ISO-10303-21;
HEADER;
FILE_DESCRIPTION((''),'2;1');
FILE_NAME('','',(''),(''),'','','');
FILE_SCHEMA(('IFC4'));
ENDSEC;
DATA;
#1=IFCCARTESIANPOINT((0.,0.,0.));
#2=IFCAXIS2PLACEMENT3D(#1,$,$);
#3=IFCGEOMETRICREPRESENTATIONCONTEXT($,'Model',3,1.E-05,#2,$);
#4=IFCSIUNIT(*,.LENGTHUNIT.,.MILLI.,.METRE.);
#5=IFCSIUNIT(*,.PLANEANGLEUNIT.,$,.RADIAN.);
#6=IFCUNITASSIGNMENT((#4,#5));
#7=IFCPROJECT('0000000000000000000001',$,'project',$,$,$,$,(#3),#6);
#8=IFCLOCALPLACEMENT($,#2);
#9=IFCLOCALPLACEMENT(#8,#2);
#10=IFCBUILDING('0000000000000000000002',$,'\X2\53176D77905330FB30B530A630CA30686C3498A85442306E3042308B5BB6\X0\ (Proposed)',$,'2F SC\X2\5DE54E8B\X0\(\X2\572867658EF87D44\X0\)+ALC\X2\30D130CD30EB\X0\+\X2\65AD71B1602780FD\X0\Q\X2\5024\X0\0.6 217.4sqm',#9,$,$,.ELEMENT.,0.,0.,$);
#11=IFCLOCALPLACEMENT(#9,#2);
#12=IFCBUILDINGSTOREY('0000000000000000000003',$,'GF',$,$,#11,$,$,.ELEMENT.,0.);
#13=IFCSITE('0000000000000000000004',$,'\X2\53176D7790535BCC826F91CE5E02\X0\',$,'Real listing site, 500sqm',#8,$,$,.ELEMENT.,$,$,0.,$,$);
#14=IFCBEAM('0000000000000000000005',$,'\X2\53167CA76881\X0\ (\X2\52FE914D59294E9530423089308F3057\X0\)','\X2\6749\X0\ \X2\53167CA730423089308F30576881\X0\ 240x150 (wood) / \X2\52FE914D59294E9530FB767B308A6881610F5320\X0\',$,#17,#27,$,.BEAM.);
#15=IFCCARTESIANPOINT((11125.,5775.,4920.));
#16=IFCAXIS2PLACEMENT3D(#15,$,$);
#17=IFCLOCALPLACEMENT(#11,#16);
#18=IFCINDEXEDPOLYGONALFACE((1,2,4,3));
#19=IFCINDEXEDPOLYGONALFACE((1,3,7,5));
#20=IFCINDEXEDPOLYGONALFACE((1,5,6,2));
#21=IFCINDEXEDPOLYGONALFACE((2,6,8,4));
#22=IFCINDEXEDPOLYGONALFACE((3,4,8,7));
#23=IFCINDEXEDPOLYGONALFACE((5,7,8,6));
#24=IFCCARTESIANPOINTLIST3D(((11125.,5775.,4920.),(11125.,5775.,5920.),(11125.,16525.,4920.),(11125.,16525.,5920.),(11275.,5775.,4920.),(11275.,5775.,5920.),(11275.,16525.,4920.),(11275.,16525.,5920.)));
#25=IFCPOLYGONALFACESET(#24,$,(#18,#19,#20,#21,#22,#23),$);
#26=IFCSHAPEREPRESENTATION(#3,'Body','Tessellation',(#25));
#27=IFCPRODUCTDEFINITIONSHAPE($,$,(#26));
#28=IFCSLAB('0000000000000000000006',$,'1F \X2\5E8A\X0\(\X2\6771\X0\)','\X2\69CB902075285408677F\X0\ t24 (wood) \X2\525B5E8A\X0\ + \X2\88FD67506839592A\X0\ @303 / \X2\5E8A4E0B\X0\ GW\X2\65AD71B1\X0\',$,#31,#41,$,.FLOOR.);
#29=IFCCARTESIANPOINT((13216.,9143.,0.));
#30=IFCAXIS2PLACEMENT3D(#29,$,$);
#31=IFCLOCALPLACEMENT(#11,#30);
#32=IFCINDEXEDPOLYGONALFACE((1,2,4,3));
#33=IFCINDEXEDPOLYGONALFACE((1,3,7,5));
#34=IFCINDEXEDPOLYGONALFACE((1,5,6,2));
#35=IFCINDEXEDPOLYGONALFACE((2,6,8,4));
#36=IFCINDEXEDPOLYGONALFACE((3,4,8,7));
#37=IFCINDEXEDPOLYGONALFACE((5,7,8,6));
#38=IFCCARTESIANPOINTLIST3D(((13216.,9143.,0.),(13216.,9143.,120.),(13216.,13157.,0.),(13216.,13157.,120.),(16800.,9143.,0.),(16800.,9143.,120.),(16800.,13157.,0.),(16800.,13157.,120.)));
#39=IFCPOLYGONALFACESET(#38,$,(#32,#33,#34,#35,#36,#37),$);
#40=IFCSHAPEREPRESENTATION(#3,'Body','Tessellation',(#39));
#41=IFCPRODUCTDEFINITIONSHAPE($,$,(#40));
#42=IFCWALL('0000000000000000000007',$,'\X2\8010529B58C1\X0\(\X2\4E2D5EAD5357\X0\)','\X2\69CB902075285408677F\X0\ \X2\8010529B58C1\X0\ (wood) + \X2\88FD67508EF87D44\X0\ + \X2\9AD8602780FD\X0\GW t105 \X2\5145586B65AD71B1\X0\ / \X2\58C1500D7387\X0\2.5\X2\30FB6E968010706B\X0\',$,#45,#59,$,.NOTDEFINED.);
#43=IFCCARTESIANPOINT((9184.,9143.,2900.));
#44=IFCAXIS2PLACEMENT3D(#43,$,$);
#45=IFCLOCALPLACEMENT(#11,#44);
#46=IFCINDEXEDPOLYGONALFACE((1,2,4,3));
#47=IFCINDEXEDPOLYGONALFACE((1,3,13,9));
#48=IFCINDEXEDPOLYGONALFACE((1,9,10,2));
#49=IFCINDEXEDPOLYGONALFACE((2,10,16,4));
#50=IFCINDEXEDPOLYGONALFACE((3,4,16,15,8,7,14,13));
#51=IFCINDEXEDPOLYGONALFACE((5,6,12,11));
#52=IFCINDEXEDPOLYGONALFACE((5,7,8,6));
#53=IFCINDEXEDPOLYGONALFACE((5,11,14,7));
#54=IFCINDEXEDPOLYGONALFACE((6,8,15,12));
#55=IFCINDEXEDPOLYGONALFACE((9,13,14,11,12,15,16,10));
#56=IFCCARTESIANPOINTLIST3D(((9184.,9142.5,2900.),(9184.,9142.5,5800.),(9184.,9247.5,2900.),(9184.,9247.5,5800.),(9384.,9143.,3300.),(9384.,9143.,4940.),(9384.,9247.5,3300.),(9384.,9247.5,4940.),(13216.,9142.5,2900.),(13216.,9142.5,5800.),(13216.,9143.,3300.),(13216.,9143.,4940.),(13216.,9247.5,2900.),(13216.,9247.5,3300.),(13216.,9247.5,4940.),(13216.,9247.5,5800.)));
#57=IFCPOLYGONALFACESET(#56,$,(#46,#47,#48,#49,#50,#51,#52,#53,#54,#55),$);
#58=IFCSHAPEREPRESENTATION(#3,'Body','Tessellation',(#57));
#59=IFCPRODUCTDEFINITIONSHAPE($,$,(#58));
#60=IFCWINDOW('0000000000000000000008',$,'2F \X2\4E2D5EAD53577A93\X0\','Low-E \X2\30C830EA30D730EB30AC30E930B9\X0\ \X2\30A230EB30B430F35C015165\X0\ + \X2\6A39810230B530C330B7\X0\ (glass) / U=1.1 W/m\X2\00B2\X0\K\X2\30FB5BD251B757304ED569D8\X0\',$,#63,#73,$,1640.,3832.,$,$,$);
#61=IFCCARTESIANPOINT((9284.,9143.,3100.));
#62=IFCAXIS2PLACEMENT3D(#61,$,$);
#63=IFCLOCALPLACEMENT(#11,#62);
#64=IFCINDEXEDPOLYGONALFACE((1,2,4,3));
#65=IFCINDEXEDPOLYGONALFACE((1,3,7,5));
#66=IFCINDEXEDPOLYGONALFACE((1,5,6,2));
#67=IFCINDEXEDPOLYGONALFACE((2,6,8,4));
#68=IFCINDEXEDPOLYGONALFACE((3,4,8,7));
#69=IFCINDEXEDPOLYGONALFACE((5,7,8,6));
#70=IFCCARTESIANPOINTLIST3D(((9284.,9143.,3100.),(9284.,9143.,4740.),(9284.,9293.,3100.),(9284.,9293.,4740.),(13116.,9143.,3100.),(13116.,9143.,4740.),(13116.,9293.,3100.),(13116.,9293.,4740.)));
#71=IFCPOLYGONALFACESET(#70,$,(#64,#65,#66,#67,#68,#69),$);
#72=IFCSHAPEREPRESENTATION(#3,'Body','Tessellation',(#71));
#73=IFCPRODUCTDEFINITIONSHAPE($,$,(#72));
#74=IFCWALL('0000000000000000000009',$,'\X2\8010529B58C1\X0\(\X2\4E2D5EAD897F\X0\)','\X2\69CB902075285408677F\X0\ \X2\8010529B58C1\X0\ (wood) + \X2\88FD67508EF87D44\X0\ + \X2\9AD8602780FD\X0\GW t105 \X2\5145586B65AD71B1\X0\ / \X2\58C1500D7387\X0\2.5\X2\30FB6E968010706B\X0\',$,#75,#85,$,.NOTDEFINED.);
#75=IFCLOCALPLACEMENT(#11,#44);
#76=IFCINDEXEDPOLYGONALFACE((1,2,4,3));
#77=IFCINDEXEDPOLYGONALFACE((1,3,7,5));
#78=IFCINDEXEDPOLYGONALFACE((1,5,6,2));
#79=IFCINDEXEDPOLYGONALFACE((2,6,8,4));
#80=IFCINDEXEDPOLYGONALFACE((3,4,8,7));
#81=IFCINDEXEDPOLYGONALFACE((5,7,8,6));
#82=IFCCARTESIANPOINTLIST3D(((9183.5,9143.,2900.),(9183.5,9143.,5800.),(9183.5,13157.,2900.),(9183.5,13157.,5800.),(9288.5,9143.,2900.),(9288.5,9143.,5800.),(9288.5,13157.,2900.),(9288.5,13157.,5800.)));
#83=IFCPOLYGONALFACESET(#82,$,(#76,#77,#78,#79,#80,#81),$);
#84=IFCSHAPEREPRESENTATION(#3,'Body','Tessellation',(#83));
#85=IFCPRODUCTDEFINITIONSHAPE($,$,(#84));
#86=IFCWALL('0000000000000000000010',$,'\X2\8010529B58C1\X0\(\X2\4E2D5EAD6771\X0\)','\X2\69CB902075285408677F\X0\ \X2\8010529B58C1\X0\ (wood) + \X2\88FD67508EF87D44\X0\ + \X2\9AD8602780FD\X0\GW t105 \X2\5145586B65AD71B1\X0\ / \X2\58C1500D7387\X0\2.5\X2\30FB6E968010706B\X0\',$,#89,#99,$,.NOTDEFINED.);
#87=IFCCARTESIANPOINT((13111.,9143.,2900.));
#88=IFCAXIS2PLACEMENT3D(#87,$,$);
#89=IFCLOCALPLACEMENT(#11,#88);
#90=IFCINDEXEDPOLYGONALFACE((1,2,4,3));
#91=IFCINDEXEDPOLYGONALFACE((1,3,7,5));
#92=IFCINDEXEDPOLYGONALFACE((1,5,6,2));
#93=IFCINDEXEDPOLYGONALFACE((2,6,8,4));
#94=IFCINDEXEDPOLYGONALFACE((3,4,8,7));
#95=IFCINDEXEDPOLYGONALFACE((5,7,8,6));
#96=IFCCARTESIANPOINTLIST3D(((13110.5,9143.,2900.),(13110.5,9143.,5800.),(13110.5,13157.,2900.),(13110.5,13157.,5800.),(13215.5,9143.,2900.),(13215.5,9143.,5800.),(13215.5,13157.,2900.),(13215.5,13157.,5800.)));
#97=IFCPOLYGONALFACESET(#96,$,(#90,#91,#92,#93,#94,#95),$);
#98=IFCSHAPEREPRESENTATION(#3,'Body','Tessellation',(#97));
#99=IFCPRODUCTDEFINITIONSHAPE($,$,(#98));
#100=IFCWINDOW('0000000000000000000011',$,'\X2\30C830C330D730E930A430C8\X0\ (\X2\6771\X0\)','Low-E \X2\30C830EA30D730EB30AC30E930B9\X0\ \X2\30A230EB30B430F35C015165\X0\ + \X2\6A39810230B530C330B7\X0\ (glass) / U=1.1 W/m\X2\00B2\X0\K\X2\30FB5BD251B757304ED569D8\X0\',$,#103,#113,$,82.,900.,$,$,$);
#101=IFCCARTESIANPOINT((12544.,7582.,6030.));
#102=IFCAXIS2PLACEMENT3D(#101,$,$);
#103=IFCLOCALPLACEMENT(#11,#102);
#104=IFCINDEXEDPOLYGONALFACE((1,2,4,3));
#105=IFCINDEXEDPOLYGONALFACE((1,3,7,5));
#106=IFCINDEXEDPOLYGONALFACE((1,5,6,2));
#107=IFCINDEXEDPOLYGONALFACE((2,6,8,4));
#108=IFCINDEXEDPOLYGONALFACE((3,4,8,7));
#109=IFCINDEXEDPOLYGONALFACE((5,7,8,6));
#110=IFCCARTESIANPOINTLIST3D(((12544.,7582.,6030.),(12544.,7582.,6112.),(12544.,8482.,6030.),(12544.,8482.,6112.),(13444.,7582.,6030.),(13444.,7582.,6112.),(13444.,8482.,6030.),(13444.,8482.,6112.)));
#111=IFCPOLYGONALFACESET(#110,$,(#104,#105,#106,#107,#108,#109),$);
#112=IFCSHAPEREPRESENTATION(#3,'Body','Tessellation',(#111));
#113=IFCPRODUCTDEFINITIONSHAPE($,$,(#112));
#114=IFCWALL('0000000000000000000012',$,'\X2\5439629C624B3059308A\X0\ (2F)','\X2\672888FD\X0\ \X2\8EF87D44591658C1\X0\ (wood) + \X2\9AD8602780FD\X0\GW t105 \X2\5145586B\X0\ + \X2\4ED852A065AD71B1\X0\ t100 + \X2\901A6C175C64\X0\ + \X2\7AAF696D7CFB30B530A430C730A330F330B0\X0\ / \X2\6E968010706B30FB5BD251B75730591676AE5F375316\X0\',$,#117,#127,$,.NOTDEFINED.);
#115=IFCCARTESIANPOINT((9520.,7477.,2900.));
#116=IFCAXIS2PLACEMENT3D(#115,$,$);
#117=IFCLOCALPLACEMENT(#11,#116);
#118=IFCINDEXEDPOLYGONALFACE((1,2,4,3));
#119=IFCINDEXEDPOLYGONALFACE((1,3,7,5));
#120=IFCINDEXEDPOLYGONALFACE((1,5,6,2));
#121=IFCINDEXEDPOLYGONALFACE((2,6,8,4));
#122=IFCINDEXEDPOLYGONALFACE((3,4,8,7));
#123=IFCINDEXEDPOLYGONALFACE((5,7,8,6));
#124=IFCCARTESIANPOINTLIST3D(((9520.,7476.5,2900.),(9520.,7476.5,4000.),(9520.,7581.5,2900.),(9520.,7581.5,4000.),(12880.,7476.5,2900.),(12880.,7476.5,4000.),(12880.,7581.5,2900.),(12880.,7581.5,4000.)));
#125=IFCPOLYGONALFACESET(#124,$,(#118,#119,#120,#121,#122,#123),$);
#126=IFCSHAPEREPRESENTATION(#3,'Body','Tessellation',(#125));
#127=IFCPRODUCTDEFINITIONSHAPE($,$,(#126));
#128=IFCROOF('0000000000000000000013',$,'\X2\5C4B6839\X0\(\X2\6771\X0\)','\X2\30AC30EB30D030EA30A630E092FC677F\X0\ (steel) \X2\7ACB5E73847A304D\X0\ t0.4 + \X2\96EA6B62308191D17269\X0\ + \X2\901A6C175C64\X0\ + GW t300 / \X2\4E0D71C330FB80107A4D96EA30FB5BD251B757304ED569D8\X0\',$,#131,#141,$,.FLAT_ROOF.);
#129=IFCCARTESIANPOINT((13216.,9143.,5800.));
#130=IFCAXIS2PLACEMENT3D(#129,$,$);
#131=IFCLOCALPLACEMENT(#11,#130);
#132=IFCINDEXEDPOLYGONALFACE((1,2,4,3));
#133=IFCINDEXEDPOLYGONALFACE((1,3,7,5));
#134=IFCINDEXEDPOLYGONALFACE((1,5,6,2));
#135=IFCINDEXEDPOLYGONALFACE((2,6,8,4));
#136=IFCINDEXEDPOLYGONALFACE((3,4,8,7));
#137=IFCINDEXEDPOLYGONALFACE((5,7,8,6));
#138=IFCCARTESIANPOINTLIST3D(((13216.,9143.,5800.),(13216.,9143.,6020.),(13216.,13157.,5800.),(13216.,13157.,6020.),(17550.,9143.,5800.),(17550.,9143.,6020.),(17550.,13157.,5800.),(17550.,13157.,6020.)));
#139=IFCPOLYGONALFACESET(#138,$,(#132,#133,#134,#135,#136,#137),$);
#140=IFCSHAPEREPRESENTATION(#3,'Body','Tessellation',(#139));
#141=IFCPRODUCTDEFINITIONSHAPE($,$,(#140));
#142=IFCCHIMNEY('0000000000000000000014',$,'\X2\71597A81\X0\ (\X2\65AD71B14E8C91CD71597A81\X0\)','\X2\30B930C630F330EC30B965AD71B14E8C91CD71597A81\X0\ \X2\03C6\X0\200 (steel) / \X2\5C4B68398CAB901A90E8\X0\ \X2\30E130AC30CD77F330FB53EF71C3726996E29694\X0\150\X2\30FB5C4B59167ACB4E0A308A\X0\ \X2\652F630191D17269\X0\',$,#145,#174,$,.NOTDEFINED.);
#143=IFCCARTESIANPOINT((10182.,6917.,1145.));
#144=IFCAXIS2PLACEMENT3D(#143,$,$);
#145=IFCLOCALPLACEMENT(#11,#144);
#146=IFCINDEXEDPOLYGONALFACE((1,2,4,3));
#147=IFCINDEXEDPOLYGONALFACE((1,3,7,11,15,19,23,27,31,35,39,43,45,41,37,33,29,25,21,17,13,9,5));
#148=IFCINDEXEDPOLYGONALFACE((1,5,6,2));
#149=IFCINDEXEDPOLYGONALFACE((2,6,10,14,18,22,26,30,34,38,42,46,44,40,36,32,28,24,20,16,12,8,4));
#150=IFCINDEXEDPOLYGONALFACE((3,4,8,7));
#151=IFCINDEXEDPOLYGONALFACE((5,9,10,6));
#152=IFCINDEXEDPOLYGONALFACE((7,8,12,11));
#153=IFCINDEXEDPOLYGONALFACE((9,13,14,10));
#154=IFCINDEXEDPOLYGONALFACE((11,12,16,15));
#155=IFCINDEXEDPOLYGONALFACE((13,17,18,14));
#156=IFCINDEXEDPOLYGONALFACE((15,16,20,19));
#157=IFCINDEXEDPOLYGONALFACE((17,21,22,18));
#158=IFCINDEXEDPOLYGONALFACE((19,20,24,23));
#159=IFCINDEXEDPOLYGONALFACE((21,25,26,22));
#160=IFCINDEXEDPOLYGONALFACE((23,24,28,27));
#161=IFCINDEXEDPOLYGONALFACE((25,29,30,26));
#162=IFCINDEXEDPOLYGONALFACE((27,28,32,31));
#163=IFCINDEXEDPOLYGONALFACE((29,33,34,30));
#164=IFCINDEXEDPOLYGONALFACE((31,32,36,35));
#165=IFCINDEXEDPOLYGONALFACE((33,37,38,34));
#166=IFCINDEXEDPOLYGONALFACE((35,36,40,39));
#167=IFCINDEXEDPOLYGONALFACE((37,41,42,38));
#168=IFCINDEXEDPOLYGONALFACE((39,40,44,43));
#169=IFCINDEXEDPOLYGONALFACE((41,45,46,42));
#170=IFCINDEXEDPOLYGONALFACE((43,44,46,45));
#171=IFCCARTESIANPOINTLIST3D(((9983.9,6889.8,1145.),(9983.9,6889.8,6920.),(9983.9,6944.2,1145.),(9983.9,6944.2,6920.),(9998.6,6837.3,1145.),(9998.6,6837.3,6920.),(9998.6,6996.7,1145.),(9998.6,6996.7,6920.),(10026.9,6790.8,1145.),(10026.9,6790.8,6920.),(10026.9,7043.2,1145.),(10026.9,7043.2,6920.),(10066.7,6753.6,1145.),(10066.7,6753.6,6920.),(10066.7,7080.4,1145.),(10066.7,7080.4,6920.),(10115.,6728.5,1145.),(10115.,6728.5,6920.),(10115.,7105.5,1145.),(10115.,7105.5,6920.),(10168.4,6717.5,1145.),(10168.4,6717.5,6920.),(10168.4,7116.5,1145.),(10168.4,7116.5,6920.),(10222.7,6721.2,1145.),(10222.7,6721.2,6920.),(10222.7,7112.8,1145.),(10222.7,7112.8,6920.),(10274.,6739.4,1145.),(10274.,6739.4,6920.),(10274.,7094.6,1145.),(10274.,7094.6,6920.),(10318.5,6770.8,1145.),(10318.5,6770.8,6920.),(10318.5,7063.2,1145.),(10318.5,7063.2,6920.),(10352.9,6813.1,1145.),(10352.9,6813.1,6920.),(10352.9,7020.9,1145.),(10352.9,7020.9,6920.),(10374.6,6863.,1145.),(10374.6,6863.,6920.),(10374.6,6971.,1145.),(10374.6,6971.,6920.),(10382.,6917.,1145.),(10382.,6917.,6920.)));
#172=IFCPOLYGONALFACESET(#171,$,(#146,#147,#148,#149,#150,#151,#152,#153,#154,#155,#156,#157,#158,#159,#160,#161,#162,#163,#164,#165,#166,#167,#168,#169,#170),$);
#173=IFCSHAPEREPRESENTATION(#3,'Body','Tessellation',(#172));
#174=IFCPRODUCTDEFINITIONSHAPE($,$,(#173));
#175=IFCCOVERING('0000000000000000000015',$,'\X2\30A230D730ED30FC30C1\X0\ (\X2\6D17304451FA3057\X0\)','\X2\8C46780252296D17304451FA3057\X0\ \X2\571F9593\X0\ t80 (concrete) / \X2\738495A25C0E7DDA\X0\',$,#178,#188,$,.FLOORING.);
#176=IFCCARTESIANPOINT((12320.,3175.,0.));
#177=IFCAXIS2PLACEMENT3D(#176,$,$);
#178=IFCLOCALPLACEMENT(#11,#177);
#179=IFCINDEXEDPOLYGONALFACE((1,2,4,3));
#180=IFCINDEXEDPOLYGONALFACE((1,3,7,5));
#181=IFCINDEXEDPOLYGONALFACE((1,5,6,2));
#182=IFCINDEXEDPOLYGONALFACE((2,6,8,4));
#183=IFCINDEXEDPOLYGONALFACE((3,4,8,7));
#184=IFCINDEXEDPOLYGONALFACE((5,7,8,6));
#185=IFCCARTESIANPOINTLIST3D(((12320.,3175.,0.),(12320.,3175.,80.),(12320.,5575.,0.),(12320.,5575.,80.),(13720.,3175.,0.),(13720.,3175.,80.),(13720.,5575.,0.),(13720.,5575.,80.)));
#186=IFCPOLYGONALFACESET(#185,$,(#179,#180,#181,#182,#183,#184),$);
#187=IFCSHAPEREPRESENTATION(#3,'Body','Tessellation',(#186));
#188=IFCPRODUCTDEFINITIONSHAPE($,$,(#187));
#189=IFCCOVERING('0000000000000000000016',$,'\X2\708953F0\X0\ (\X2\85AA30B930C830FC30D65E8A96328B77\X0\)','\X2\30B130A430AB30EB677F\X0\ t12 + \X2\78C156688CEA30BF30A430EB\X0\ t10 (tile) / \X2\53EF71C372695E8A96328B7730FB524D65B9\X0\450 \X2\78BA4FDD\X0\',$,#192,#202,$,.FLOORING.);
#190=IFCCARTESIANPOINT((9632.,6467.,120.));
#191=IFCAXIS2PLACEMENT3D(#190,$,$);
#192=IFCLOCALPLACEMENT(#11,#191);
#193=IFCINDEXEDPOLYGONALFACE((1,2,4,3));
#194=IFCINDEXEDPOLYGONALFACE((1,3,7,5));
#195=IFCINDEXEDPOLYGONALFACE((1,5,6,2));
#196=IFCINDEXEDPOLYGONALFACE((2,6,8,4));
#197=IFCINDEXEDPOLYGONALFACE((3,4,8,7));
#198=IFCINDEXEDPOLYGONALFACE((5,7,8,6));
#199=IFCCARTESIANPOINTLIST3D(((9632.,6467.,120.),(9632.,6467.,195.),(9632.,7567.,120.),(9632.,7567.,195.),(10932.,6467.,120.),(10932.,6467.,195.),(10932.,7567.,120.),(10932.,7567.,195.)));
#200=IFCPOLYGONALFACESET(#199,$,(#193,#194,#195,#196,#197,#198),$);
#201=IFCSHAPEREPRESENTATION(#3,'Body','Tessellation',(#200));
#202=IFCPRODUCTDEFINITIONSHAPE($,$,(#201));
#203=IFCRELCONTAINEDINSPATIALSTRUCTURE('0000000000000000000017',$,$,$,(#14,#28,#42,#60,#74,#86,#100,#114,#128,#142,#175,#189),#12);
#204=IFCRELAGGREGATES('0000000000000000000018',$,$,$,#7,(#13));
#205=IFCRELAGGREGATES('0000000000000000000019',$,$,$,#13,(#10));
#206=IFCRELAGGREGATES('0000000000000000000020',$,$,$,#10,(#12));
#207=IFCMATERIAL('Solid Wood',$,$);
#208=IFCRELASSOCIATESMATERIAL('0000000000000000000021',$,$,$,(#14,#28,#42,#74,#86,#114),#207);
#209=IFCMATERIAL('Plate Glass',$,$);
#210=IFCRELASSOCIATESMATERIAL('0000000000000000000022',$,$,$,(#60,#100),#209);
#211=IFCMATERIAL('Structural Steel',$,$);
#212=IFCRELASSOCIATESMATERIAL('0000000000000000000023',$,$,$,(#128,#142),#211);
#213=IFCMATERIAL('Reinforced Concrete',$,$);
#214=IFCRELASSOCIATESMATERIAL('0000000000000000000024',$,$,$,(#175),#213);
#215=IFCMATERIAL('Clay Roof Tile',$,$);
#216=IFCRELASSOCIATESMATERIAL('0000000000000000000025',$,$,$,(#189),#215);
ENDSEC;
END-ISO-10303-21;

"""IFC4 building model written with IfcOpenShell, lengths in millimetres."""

from ifc_helpers import new_model, si_unit, frame, frame_2d, origin, origin_2d, place, context, project, spatial, rectangle, circle, extrude, material, element, fill, save


model = new_model("IFC4")

# Units and contexts
model_context = context("Model", 3, precision=1e-05, world=origin())
ifc_project = project(units=[si_unit("LENGTHUNIT", "METRE", prefix="MILLI"), si_unit("PLANEANGLEUNIT", "RADIAN")], contexts=[model_context])

# Site, building, storey
site_placement = place(None, origin())
site = spatial("IfcSite", under=ifc_project, at=site_placement, Name="北海道富良野市", ObjectType="Real listing site, 500sqm", CompositionType="ELEMENT", RefElevation=0.0)
building_placement = place(site_placement, origin())
building = spatial("IfcBuilding", under=site, at=building_placement, Name="北海道・サウナと水風呂のある家 (Proposed)", ObjectType="2F SC工事(在来軸組)+ALCパネル+断熱性能Q値0.6 217.4sqm", CompositionType="ELEMENT", ElevationOfRefHeight=0.0, ElevationOfTerrain=0.0)
storey_placement = place(building_placement, origin())
storey = spatial("IfcBuildingStorey", under=building, at=storey_placement, Name="GF", CompositionType="ELEMENT", Elevation=0.0)

# Shared definitions
ifc_material_1 = material(Name="Solid Wood")

# Beam
beam_placement = place(storey_placement, frame((11125.0, 5775.0, 4920.0)))
element("IfcBeam", 1, at=beam_placement, inside=storey, material=ifc_material_1, Name="化粧梁 (勾配天井あらわし)", Description="杉 化粧あらわし梁 240x150 (wood) / 勾配天井・登り梁意匠", PredefinedType="BEAM", context=model_context, shape_type="SweptSolid", body=[
    extrude(rectangle(XDim=150.0, YDim=10750.0, at=frame_2d((75.0, 5375.0))), frame((11125.0, 5775.0, 4920.0)), (0.0, 0.0, 1.0), 1000.0),
])

# Slab
slab_placement = place(storey_placement, frame((13216.0, 9143.0, 0.0)))
element("IfcSlab", 2, at=slab_placement, inside=storey, material=ifc_material_1, Name="1F 床(東)", Description="構造用合板 t24 (wood) 剛床 + 製材根太 @303 / 床下 GW断熱", PredefinedType="FLOOR", context=model_context, shape_type="SweptSolid", body=[
    extrude(rectangle(XDim=3584.0, YDim=4014.0, at=frame_2d((1792.0, 2007.0))), frame((13216.0, 9143.0, 0.0)), (0.0, 0.0, 1.0), 120.0),
])

# Wall, opening, window
wall_1_placement = place(storey_placement, frame((9184.0, 9143.0, 2900.0)))
wall_1 = element("IfcWall", 3, at=wall_1_placement, inside=storey, material=ifc_material_1, Name="耐力壁(中庭南)", Description="構造用合板 耐力壁 (wood) + 製材軸組 + 高性能GW t105 充填断熱 / 壁倍率2.5・準耐火", PredefinedType="NOTDEFINED", context=model_context, shape_type="SweptSolid", body=[
    extrude(rectangle(XDim=4032.0, YDim=105.0, at=frame_2d((2016.0, 52.0))), frame((9184.0, 9143.0, 2900.0)), (0.0, 0.0, 1.0), 2900.0),
])
opening_placement = place(storey_placement, frame((9284.0, 9143.0, 3100.0)))
opening = element("IfcOpeningElement", 4, at=opening_placement, cuts=wall_1, PredefinedType="NOTDEFINED", context=model_context, shape_type="SweptSolid", body=[
    extrude(rectangle(XDim=3832.0, YDim=150.0, at=frame_2d((1916.0, 75.0))), frame((9284.0, 9143.0, 3100.0)), (0.0, 0.0, 1.0), 1640.0),
])
ifc_material_2 = material(Name="Plate Glass")
window_1_placement = place(storey_placement, frame((9284.0, 9143.0, 3100.0)))
window_1 = element("IfcWindow", 5, at=window_1_placement, inside=storey, material=ifc_material_2, Name="2F 中庭南窓", Description="Low-E トリプルガラス アルゴン封入 + 樹脂サッシ (glass) / U=1.1 W/m²K・寒冷地仕様", OverallHeight=1640.0, OverallWidth=3832.0, context=model_context, shape_type="SweptSolid", body=[
    extrude(rectangle(XDim=3832.0, YDim=150.0, at=frame_2d((1916.0, 75.0))), frame((9284.0, 9143.0, 3100.0)), (0.0, 0.0, 1.0), 1640.0),
])
fill(opening, window_1)

# Walls
wall_2_placement = place(storey_placement, frame((9184.0, 9143.0, 2900.0)))
element("IfcWall", 6, at=wall_2_placement, inside=storey, material=ifc_material_1, Name="耐力壁(中庭西)", Description="構造用合板 耐力壁 (wood) + 製材軸組 + 高性能GW t105 充填断熱 / 壁倍率2.5・準耐火", PredefinedType="NOTDEFINED", context=model_context, shape_type="SweptSolid", body=[
    extrude(rectangle(XDim=105.0, YDim=4014.0, at=frame_2d((52.0, 2007.0))), frame((9184.0, 9143.0, 2900.0)), (0.0, 0.0, 1.0), 2900.0),
])
wall_3_placement = place(storey_placement, frame((13111.0, 9143.0, 2900.0)))
element("IfcWall", 7, at=wall_3_placement, inside=storey, material=ifc_material_1, Name="耐力壁(中庭東)", Description="構造用合板 耐力壁 (wood) + 製材軸組 + 高性能GW t105 充填断熱 / 壁倍率2.5・準耐火", PredefinedType="NOTDEFINED", context=model_context, shape_type="SweptSolid", body=[
    extrude(rectangle(XDim=105.0, YDim=4014.0, at=frame_2d((52.0, 2007.0))), frame((13111.0, 9143.0, 2900.0)), (0.0, 0.0, 1.0), 2900.0),
])

# Window
window_2_placement = place(storey_placement, frame((12544.0, 7582.0, 6030.0)))
element("IfcWindow", 8, at=window_2_placement, inside=storey, material=ifc_material_2, Name="トップライト (東)", Description="Low-E トリプルガラス アルゴン封入 + 樹脂サッシ (glass) / U=1.1 W/m²K・寒冷地仕様", OverallHeight=82.0, OverallWidth=900.0, context=model_context, shape_type="SweptSolid", body=[
    extrude(rectangle(XDim=900.0, YDim=900.0, at=frame_2d((450.0, 450.0))), frame((12544.0, 7582.0, 6030.0)), (0.0, 0.0, 1.0), 82.0),
])

# Wall
wall_4_placement = place(storey_placement, frame((9520.0, 7477.0, 2900.0)))
element("IfcWall", 9, at=wall_4_placement, inside=storey, material=ifc_material_1, Name="吹抜手すり (2F)", Description="木製 軸組外壁 (wood) + 高性能GW t105 充填 + 付加断熱 t100 + 通気層 + 窯業系サイディング / 準耐火・寒冷地外皮強化", PredefinedType="NOTDEFINED", context=model_context, shape_type="SweptSolid", body=[
    extrude(rectangle(XDim=3360.0, YDim=105.0, at=frame_2d((1680.0, 52.0))), frame((9520.0, 7477.0, 2900.0)), (0.0, 0.0, 1.0), 1100.0),
])

# Roof
ifc_material_3 = material(Name="Structural Steel")
roof_placement = place(storey_placement, frame((13216.0, 9143.0, 5800.0)))
element("IfcRoof", 10, at=roof_placement, inside=storey, material=ifc_material_3, Name="屋根(東)", Description="ガルバリウム鋼板 (steel) 立平葺き t0.4 + 雪止め金物 + 通気層 + GW t300 / 不燃・耐積雪・寒冷地仕様", PredefinedType="FLAT_ROOF", context=model_context, shape_type="SweptSolid", body=[
    extrude(rectangle(XDim=4334.0, YDim=4014.0, at=frame_2d((2167.0, 2007.0))), frame((13216.0, 9143.0, 5800.0)), (0.0, 0.0, 1.0), 220.0),
])

# Chimney
chimney_placement = place(storey_placement, frame((10182.0, 6917.0, 1145.0)))
element("IfcChimney", 11, at=chimney_placement, inside=storey, material=ifc_material_3, Name="煙突 (断熱二重煙突)", Description="ステンレス断熱二重煙突 φ200 (steel) / 屋根貫通部 メガネ石・可燃物離隔150・屋外立上り 支持金物", PredefinedType="NOTDEFINED", context=model_context, shape_type="SweptSolid", body=[
    extrude(circle(Radius=200.0, at=origin_2d()), frame((10182.0, 6917.0, 1145.0)), (0.0, 0.0, 1.0), 5775.0),
])

# Coverings
ifc_material_4 = material(Name="Reinforced Concrete")
covering_1_placement = place(storey_placement, frame((12320.0, 3175.0, 0.0)))
element("IfcCovering", 12, at=covering_1_placement, inside=storey, material=ifc_material_4, Name="アプローチ (洗い出し)", Description="豆砂利洗い出し 土間 t80 (concrete) / 玄関導線", PredefinedType="FLOORING", context=model_context, shape_type="SweptSolid", body=[
    extrude(rectangle(XDim=1400.0, YDim=2400.0, at=frame_2d((700.0, 1200.0))), frame((12320.0, 3175.0, 0.0)), (0.0, 0.0, 1.0), 80.0),
])
ifc_material_5 = material(Name="Clay Roof Tile")
covering_2_placement = place(storey_placement, frame((9632.0, 6467.0, 120.0)))
element("IfcCovering", 13, at=covering_2_placement, inside=storey, material=ifc_material_5, Name="炉台 (薪ストーブ床防護)", Description="ケイカル板 t12 + 磁器質タイル t10 (tile) / 可燃物床防護・前方450 確保", PredefinedType="FLOORING", context=model_context, shape_type="SweptSolid", body=[
    extrude(rectangle(XDim=1300.0, YDim=1100.0, at=frame_2d((650.0, 550.0))), frame((9632.0, 6467.0, 120.0)), (0.0, 0.0, 1.0), 75.0),
])

save(model, "model.ifc")
